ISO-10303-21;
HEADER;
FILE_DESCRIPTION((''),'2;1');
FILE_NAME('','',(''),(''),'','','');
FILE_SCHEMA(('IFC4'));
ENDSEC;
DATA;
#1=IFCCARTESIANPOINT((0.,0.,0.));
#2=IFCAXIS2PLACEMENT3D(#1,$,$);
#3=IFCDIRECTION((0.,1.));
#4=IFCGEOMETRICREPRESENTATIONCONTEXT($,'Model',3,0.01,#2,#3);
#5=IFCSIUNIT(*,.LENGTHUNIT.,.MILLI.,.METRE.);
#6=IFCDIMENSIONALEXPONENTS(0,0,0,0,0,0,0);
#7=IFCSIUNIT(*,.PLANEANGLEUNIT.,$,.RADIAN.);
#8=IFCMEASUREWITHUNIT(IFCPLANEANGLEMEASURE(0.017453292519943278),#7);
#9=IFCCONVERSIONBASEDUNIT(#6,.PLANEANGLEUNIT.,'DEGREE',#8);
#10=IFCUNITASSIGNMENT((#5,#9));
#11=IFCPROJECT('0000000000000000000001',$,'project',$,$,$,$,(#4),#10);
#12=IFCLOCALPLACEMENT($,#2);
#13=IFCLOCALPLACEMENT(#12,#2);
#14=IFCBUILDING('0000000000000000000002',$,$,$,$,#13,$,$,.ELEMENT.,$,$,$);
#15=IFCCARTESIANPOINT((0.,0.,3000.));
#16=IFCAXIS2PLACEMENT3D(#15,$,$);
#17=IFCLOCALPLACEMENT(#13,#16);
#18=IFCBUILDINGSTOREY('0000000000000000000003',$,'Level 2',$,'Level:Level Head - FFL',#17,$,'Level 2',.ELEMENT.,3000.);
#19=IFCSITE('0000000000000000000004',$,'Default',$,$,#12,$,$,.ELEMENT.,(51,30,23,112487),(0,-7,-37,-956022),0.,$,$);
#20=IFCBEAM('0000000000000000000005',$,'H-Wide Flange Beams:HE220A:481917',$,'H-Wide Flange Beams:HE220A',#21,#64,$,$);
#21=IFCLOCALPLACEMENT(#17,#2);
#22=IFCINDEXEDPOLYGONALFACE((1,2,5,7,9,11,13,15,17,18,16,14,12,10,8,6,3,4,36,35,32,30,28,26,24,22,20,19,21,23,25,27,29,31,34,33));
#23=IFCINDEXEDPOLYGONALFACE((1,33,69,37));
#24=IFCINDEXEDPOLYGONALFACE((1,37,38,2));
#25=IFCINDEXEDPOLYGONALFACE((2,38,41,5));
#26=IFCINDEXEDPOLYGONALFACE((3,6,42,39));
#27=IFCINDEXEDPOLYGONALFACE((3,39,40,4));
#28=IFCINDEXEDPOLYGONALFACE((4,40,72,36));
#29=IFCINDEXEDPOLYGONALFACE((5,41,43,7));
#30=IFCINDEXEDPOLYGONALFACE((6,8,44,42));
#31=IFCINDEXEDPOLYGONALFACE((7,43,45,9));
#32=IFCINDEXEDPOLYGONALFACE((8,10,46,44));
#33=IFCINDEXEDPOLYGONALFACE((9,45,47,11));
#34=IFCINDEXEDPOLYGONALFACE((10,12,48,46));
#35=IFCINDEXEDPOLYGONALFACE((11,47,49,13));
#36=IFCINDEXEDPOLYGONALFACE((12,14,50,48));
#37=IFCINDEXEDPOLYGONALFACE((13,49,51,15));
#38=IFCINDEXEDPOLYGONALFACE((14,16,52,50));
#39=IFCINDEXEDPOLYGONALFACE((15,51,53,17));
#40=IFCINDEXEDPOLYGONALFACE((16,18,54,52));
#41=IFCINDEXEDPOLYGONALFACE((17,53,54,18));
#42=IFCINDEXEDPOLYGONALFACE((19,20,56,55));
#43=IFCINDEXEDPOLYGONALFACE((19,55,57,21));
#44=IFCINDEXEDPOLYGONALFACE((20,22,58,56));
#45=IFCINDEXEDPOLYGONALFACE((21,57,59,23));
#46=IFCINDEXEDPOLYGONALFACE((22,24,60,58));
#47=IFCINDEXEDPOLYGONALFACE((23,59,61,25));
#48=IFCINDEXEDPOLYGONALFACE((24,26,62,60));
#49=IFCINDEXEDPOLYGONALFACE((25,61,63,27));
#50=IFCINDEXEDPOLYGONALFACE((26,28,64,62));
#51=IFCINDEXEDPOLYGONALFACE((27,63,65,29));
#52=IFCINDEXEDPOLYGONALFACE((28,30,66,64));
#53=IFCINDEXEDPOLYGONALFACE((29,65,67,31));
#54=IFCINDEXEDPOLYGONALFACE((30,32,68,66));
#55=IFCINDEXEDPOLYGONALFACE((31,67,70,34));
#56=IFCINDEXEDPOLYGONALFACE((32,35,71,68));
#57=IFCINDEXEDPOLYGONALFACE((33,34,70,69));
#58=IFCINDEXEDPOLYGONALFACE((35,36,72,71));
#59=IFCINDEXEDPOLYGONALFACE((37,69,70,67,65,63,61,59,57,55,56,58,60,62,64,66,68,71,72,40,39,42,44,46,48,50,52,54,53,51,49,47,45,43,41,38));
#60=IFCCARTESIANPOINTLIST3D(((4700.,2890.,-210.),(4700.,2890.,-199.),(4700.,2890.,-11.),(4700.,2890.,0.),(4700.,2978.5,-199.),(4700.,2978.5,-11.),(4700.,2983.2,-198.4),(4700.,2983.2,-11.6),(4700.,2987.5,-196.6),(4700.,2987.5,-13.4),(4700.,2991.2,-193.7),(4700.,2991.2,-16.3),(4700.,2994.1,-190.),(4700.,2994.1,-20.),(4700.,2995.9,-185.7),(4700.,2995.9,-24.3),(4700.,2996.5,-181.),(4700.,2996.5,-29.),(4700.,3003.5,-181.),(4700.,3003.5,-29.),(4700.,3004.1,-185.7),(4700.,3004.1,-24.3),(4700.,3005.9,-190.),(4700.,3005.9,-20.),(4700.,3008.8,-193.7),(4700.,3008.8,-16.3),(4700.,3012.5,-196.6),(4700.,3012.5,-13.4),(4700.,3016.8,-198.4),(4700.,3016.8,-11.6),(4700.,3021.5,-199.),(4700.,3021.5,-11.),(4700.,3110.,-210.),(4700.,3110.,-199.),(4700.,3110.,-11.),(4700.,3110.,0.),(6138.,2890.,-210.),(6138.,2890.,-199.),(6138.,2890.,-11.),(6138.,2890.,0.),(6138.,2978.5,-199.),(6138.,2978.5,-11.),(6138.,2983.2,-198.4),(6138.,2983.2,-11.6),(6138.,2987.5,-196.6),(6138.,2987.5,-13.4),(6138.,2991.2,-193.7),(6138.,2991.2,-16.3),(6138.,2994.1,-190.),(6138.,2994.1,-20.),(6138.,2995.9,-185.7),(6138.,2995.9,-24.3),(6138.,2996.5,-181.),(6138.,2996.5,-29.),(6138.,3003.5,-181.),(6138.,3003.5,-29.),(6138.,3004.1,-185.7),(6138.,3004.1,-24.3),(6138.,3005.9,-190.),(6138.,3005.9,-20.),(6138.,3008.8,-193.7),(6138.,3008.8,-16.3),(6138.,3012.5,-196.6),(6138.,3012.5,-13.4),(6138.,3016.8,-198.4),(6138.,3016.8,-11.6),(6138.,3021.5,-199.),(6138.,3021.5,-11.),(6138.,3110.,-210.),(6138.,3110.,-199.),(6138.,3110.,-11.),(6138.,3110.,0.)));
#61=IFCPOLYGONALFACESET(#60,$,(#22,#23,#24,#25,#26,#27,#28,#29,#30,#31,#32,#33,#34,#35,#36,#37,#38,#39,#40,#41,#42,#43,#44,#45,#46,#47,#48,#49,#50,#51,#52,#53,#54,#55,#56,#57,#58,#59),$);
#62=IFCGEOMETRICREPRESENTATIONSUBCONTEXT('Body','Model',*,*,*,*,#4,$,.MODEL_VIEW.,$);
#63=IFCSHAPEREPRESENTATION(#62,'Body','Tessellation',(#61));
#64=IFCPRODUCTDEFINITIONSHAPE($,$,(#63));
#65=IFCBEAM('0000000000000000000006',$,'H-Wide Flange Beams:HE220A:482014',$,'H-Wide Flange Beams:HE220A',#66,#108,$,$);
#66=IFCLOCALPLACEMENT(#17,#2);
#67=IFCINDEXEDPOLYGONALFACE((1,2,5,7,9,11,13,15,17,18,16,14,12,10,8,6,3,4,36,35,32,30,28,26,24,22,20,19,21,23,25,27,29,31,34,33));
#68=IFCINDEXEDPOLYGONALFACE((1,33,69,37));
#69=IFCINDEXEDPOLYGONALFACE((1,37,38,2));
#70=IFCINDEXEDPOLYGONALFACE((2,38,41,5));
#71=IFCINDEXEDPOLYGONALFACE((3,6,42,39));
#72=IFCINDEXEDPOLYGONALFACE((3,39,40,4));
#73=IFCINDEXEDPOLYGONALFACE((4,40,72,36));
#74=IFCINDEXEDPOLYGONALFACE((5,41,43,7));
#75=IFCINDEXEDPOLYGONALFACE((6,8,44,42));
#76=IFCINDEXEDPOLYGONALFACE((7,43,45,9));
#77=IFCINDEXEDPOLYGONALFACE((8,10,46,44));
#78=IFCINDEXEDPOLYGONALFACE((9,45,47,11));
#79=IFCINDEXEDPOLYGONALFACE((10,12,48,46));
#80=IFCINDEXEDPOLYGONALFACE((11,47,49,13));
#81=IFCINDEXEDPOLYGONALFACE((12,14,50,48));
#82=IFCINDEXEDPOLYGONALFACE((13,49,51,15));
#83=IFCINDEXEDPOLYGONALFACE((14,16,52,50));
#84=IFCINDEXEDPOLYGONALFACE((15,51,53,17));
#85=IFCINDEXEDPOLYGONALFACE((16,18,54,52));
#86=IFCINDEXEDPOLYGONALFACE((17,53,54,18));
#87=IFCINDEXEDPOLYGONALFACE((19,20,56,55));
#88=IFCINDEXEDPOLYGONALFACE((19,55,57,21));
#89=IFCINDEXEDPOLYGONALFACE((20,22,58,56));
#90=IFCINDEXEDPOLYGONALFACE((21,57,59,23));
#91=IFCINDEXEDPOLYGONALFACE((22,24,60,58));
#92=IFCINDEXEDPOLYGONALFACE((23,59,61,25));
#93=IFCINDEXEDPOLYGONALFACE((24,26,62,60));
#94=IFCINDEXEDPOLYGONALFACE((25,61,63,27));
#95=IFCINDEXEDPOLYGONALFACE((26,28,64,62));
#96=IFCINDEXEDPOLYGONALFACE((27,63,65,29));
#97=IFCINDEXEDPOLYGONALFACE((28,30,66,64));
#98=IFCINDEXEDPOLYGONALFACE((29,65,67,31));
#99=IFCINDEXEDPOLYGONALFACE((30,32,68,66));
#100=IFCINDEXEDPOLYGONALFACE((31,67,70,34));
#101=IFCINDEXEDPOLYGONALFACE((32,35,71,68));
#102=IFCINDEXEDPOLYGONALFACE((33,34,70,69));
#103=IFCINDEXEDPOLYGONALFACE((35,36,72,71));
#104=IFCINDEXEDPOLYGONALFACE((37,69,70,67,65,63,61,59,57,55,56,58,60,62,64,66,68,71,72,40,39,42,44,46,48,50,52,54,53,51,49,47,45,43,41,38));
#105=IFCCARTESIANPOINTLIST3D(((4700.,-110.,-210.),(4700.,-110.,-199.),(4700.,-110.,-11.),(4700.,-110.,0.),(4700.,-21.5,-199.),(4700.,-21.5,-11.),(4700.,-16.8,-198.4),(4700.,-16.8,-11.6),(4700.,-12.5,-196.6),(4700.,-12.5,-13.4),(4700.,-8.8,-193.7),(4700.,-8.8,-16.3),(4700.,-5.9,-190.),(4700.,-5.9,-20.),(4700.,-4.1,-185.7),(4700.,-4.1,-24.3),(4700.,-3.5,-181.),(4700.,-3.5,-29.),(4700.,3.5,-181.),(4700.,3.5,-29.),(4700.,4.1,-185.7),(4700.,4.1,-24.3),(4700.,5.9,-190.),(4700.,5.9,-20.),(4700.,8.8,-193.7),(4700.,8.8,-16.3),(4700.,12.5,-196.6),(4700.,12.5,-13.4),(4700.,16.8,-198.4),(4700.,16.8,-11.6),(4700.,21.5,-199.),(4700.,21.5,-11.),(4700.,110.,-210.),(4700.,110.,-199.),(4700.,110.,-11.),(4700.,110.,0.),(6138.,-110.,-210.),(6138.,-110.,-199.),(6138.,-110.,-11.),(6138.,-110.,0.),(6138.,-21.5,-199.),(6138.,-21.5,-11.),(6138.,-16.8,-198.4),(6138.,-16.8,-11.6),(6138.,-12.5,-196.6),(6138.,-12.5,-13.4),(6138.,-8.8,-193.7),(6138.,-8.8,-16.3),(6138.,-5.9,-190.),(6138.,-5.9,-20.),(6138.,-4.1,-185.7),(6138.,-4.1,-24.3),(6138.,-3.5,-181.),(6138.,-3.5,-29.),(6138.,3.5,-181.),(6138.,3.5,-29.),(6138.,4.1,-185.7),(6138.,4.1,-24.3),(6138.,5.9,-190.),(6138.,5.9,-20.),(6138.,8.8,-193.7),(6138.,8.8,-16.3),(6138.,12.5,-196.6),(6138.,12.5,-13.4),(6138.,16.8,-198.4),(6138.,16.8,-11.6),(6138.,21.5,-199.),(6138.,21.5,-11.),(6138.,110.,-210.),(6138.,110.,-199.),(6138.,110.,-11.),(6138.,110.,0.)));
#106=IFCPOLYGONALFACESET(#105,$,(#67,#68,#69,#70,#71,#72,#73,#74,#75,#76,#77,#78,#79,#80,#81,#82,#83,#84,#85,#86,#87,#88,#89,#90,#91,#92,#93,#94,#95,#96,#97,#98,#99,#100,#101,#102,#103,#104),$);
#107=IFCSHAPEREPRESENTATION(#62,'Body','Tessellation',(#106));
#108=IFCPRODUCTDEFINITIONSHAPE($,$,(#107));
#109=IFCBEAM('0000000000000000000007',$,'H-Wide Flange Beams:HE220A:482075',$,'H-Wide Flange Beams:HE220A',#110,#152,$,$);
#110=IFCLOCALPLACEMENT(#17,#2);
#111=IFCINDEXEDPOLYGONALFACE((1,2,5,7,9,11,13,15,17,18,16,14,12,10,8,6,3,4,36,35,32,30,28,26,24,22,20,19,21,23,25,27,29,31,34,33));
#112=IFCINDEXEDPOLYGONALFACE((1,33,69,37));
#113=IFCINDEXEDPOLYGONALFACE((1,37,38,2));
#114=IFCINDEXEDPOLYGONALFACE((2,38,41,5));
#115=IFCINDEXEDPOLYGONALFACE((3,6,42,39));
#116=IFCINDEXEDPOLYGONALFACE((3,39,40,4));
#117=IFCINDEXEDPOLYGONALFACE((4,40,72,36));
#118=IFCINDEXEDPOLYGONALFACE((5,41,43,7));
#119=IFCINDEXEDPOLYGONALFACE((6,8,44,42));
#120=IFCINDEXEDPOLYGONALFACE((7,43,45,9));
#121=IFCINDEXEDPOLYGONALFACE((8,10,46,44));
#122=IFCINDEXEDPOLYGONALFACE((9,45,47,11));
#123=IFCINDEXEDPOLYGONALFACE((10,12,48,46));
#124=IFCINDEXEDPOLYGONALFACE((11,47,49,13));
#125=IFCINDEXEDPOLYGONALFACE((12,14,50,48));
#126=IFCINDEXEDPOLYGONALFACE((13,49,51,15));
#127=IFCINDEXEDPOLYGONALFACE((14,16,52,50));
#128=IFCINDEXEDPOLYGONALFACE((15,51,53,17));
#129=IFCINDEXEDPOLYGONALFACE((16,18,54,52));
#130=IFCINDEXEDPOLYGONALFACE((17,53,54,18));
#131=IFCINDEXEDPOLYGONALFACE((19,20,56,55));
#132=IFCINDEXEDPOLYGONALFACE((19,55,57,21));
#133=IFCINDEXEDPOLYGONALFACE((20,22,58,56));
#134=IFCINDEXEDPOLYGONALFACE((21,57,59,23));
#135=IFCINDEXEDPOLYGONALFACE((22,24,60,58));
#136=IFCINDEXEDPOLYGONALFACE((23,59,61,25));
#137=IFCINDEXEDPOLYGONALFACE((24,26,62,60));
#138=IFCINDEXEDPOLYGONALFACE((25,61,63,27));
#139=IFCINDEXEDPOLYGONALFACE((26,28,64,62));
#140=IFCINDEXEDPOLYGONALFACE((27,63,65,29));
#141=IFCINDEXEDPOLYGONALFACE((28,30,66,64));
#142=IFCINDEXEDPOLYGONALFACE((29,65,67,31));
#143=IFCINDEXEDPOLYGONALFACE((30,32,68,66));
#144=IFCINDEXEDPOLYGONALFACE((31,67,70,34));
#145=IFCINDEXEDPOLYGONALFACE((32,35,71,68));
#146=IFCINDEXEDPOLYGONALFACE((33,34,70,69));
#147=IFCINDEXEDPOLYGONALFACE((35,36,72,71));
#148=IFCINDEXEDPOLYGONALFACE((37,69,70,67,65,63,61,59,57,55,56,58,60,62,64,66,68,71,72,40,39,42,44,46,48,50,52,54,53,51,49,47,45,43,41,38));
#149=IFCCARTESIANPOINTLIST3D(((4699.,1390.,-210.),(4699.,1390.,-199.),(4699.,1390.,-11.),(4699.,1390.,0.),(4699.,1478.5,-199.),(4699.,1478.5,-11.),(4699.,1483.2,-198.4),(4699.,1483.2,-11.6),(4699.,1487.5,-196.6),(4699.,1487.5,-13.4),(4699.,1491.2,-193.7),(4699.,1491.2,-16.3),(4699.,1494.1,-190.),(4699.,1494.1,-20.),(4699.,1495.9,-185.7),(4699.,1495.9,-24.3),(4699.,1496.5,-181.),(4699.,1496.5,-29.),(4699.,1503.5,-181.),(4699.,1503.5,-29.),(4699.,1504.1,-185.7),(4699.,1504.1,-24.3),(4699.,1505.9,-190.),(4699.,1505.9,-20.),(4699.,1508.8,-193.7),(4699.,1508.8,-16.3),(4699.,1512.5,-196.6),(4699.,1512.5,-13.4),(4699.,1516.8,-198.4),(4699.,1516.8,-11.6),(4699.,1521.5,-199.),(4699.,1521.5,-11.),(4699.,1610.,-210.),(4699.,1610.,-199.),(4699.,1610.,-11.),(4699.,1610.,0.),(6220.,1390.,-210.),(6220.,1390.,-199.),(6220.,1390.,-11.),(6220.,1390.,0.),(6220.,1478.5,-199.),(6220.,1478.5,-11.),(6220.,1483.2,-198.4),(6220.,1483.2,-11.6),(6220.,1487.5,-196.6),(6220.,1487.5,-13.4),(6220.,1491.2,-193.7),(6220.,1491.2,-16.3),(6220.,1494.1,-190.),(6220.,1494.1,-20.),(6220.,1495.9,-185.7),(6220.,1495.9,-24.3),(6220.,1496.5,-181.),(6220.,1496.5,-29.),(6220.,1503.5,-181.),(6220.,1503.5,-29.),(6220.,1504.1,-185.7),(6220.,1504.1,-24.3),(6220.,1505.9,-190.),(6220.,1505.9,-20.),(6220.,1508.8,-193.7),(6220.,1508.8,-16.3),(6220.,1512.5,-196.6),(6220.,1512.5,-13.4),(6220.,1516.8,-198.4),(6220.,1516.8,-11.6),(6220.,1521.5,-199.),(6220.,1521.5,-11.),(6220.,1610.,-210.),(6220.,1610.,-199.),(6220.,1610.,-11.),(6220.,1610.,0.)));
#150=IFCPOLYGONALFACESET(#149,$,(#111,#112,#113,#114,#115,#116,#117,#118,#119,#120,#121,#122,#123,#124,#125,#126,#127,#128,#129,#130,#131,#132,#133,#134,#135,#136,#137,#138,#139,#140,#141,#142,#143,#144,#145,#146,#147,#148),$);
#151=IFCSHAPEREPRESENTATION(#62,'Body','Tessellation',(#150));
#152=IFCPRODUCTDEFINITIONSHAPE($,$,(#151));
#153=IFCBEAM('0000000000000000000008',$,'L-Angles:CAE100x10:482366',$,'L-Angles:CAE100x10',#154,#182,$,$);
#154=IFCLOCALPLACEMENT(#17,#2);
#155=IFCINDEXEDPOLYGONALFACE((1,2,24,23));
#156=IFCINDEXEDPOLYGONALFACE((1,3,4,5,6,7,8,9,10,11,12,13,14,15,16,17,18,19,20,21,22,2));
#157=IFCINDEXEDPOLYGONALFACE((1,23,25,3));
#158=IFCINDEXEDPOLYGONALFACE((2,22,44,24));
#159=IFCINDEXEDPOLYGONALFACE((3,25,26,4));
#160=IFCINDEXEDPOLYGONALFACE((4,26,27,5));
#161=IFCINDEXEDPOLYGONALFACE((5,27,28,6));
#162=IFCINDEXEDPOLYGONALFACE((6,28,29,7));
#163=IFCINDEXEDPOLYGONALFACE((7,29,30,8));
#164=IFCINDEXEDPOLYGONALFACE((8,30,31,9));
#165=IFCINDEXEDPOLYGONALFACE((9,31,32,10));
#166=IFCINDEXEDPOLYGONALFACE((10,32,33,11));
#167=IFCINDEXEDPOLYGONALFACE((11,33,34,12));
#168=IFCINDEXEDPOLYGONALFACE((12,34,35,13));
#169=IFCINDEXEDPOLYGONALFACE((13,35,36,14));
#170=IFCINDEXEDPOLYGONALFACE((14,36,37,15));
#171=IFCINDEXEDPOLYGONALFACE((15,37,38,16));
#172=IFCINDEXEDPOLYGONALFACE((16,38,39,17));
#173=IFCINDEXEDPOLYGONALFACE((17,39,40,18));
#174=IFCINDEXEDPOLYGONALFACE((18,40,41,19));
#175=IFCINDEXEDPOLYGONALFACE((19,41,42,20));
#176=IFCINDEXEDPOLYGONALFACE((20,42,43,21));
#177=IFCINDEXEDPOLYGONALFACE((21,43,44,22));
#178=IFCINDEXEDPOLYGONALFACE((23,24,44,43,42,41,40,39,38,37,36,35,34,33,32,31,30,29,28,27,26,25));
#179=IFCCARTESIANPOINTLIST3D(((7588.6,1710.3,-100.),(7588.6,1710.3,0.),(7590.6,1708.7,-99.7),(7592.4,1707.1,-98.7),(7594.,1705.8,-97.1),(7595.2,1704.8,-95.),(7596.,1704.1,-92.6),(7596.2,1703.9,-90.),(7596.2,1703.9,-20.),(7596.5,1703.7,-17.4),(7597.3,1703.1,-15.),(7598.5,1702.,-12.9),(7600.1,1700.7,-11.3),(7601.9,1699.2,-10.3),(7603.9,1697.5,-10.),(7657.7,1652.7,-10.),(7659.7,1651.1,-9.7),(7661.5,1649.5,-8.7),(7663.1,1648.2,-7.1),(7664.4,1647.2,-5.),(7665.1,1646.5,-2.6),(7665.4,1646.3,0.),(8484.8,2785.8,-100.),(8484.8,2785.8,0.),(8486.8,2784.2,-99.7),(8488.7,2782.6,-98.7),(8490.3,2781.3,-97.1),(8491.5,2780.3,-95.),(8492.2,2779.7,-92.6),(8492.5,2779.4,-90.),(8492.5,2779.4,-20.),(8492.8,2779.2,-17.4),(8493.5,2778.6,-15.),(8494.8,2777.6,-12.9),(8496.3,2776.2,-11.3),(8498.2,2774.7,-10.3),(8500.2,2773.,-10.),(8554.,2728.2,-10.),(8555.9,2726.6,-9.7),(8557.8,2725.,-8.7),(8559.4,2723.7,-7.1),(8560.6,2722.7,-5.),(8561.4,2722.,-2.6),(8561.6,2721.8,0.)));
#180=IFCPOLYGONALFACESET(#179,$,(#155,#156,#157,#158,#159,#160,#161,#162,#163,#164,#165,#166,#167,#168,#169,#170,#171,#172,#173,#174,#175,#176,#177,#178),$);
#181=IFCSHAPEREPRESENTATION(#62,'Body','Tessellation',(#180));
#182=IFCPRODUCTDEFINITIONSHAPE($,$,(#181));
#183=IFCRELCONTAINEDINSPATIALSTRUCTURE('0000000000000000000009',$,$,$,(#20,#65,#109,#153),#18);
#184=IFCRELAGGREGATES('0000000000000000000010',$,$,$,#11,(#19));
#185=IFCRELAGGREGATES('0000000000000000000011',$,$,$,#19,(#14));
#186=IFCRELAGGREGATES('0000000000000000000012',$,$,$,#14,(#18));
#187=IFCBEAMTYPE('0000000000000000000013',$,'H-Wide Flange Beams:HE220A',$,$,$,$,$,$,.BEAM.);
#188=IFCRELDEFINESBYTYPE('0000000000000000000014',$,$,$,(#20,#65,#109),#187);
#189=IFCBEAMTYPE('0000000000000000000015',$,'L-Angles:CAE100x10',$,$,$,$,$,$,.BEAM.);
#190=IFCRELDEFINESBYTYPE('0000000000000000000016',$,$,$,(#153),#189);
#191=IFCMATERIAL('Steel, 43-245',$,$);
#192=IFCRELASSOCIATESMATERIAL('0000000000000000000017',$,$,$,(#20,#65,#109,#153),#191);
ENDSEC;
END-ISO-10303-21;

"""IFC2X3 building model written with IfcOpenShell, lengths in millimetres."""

from ifc_helpers import new_model, entity, si_unit, converted_unit, direction, frame, frame_2d, origin, place, context, subcontext, project, spatial, polyline, circle_curve, parameter, trimmed, segment, composite_curve, i_section, outline, extrude, material, type_object, element, save


model = new_model("IFC2X3")

# Units and contexts
model_context = context("Model", 3, precision=0.01, world=origin(), true_north=direction((0.0, 1.0)))
body_context = subcontext(model_context, "Body", "Model", "MODEL_VIEW")
ifc_project = project(units=[si_unit("LENGTHUNIT", "METRE", prefix="MILLI"), converted_unit("PLANEANGLEUNIT", "DEGREE", entity("IfcPlaneAngleMeasure", 0.017453292519943278), si_unit("PLANEANGLEUNIT", "RADIAN"), dimensions=[0, 0, 0, 0, 0, 0, 0])], contexts=[model_context])

# Site, building, storey
site_placement = place(None, origin())
site = spatial("IfcSite", under=ifc_project, at=site_placement, Name="Default", CompositionType="ELEMENT", RefLatitude=(51, 30, 23, 112487), RefLongitude=(0, -7, -37, -956022), RefElevation=0.0)
building_placement = place(site_placement, origin())
building = spatial("IfcBuilding", under=site, at=building_placement, CompositionType="ELEMENT")
storey_placement = place(building_placement, frame((0.0, 0.0, 3000.0)))
storey = spatial("IfcBuildingStorey", under=building, at=storey_placement, Name="Level 2", ObjectType="Level:Level Head - FFL", LongName="Level 2", CompositionType="ELEMENT", Elevation=3000.0)

# Beams
ifc_material = material(Name="Steel, 43-245")
beam_type_1 = type_object("IfcBeamType", Name="H-Wide Flange Beams:HE220A", PredefinedType="BEAM")
beam_1_placement = place(storey_placement, frame((4700.0, 3000.0, 0.0)))
element("IfcBeam", 1, at=beam_1_placement, inside=storey, type_object=beam_type_1, material=ifc_material, Name="H-Wide Flange Beams:HE220A:481917", ObjectType="H-Wide Flange Beams:HE220A", context=body_context, shape_type="SweptSolid", body=[
    extrude(i_section(OverallWidth=220.0, OverallDepth=210.0, WebThickness=7.0, FlangeThickness=11.0, FilletRadius=18.0, at=frame_2d((0.0, 0.0), x_axis=(0.0, 1.0))), frame((0.0, 0.0, -105.0), z_axis=(1.0, 0.0, 0.0), x_axis=(0.0, 0.0, -1.0)), (0.0, 0.0, 1.0), 1438.0),
])
beam_2_placement = place(storey_placement, frame((4700.0, 0.0, 0.0)))
element("IfcBeam", 2, at=beam_2_placement, inside=storey, type_object=beam_type_1, material=ifc_material, Name="H-Wide Flange Beams:HE220A:482014", ObjectType="H-Wide Flange Beams:HE220A", context=body_context, shape_type="SweptSolid", body=[
    extrude(i_section(OverallWidth=220.0, OverallDepth=210.0, WebThickness=7.0, FlangeThickness=11.0, FilletRadius=18.0, at=frame_2d((0.0, 0.0), x_axis=(0.0, 1.0))), frame((0.0, 0.0, -105.0), z_axis=(1.0, 0.0, 0.0), x_axis=(0.0, 0.0, -1.0)), (0.0, 0.0, 1.0), 1438.0),
])
beam_3_placement = place(storey_placement, frame((4700.0, 1500.0, 0.0)))
element("IfcBeam", 3, at=beam_3_placement, inside=storey, type_object=beam_type_1, material=ifc_material, Name="H-Wide Flange Beams:HE220A:482075", ObjectType="H-Wide Flange Beams:HE220A", context=body_context, shape_type="SweptSolid", body=[
    extrude(i_section(OverallWidth=220.0, OverallDepth=210.0, WebThickness=7.0, FlangeThickness=11.0, FilletRadius=18.0, at=frame_2d((0.0, 0.0), x_axis=(0.0, 1.0))), frame((-1.0, 0.0, -105.0), z_axis=(1.0, 0.0, 0.0), x_axis=(0.0, 0.0, -1.0)), (0.0, 0.0, 1.0), 1521.0),
])
beam_type_2 = type_object("IfcBeamType", Name="L-Angles:CAE100x10", PredefinedType="BEAM")
beam_4_placement = place(storey_placement, frame((8700.0, 3000.0, 0.0), z_axis=(0.0, 0.0, 1.0), x_axis=(-0.640184, -0.768221, 0.0)))
element("IfcBeam", 4, at=beam_4_placement, inside=storey, type_object=beam_type_2, material=ifc_material, Name="L-Angles:CAE100x10:482366", ObjectType="L-Angles:CAE100x10", context=body_context, shape_type="SweptSolid", body=[
    extrude(outline(composite_curve([segment(polyline([(-32.9, -32.9), (67.1, -32.9)]), True, "CONTINUOUS"), segment(trimmed(circle_curve(frame_2d((57.1, -32.9), x_axis=(1.0, 0.0)), 10.0), [parameter(0.0)], [parameter(90.0)], True, "PARAMETER"), True, "CONTINUOUS"), segment(polyline([(57.1, -22.9), (-12.9, -22.9)]), True, "CONTINUOUS"), segment(trimmed(circle_curve(frame_2d((-12.9, -12.9), x_axis=(0.0, -1.0)), 10.0), [parameter(270.0)], [parameter(0.0)], True, "PARAMETER"), False, "CONTINUOUS"), segment(polyline([(-22.9, -12.9), (-22.9, 57.1)]), True, "CONTINUOUS"), segment(trimmed(circle_curve(frame_2d((-32.9, 57.1), x_axis=(1.0, 0.0)), 10.0), [parameter(0.0)], [parameter(90.0)], True, "PARAMETER"), True, "CONTINUOUS"), segment(polyline([(-32.9, 67.1), (-32.9, -32.9)]), True, "CONTINUOUS")], self_intersect=False)), frame((302.3, 4.7, -32.9), z_axis=(1.0, 0.0, 0.0), x_axis=(0.0, 0.0, -1.0)), (0.0, 0.0, 1.0), 1400.0),
])

save(model, "model.ifc")
